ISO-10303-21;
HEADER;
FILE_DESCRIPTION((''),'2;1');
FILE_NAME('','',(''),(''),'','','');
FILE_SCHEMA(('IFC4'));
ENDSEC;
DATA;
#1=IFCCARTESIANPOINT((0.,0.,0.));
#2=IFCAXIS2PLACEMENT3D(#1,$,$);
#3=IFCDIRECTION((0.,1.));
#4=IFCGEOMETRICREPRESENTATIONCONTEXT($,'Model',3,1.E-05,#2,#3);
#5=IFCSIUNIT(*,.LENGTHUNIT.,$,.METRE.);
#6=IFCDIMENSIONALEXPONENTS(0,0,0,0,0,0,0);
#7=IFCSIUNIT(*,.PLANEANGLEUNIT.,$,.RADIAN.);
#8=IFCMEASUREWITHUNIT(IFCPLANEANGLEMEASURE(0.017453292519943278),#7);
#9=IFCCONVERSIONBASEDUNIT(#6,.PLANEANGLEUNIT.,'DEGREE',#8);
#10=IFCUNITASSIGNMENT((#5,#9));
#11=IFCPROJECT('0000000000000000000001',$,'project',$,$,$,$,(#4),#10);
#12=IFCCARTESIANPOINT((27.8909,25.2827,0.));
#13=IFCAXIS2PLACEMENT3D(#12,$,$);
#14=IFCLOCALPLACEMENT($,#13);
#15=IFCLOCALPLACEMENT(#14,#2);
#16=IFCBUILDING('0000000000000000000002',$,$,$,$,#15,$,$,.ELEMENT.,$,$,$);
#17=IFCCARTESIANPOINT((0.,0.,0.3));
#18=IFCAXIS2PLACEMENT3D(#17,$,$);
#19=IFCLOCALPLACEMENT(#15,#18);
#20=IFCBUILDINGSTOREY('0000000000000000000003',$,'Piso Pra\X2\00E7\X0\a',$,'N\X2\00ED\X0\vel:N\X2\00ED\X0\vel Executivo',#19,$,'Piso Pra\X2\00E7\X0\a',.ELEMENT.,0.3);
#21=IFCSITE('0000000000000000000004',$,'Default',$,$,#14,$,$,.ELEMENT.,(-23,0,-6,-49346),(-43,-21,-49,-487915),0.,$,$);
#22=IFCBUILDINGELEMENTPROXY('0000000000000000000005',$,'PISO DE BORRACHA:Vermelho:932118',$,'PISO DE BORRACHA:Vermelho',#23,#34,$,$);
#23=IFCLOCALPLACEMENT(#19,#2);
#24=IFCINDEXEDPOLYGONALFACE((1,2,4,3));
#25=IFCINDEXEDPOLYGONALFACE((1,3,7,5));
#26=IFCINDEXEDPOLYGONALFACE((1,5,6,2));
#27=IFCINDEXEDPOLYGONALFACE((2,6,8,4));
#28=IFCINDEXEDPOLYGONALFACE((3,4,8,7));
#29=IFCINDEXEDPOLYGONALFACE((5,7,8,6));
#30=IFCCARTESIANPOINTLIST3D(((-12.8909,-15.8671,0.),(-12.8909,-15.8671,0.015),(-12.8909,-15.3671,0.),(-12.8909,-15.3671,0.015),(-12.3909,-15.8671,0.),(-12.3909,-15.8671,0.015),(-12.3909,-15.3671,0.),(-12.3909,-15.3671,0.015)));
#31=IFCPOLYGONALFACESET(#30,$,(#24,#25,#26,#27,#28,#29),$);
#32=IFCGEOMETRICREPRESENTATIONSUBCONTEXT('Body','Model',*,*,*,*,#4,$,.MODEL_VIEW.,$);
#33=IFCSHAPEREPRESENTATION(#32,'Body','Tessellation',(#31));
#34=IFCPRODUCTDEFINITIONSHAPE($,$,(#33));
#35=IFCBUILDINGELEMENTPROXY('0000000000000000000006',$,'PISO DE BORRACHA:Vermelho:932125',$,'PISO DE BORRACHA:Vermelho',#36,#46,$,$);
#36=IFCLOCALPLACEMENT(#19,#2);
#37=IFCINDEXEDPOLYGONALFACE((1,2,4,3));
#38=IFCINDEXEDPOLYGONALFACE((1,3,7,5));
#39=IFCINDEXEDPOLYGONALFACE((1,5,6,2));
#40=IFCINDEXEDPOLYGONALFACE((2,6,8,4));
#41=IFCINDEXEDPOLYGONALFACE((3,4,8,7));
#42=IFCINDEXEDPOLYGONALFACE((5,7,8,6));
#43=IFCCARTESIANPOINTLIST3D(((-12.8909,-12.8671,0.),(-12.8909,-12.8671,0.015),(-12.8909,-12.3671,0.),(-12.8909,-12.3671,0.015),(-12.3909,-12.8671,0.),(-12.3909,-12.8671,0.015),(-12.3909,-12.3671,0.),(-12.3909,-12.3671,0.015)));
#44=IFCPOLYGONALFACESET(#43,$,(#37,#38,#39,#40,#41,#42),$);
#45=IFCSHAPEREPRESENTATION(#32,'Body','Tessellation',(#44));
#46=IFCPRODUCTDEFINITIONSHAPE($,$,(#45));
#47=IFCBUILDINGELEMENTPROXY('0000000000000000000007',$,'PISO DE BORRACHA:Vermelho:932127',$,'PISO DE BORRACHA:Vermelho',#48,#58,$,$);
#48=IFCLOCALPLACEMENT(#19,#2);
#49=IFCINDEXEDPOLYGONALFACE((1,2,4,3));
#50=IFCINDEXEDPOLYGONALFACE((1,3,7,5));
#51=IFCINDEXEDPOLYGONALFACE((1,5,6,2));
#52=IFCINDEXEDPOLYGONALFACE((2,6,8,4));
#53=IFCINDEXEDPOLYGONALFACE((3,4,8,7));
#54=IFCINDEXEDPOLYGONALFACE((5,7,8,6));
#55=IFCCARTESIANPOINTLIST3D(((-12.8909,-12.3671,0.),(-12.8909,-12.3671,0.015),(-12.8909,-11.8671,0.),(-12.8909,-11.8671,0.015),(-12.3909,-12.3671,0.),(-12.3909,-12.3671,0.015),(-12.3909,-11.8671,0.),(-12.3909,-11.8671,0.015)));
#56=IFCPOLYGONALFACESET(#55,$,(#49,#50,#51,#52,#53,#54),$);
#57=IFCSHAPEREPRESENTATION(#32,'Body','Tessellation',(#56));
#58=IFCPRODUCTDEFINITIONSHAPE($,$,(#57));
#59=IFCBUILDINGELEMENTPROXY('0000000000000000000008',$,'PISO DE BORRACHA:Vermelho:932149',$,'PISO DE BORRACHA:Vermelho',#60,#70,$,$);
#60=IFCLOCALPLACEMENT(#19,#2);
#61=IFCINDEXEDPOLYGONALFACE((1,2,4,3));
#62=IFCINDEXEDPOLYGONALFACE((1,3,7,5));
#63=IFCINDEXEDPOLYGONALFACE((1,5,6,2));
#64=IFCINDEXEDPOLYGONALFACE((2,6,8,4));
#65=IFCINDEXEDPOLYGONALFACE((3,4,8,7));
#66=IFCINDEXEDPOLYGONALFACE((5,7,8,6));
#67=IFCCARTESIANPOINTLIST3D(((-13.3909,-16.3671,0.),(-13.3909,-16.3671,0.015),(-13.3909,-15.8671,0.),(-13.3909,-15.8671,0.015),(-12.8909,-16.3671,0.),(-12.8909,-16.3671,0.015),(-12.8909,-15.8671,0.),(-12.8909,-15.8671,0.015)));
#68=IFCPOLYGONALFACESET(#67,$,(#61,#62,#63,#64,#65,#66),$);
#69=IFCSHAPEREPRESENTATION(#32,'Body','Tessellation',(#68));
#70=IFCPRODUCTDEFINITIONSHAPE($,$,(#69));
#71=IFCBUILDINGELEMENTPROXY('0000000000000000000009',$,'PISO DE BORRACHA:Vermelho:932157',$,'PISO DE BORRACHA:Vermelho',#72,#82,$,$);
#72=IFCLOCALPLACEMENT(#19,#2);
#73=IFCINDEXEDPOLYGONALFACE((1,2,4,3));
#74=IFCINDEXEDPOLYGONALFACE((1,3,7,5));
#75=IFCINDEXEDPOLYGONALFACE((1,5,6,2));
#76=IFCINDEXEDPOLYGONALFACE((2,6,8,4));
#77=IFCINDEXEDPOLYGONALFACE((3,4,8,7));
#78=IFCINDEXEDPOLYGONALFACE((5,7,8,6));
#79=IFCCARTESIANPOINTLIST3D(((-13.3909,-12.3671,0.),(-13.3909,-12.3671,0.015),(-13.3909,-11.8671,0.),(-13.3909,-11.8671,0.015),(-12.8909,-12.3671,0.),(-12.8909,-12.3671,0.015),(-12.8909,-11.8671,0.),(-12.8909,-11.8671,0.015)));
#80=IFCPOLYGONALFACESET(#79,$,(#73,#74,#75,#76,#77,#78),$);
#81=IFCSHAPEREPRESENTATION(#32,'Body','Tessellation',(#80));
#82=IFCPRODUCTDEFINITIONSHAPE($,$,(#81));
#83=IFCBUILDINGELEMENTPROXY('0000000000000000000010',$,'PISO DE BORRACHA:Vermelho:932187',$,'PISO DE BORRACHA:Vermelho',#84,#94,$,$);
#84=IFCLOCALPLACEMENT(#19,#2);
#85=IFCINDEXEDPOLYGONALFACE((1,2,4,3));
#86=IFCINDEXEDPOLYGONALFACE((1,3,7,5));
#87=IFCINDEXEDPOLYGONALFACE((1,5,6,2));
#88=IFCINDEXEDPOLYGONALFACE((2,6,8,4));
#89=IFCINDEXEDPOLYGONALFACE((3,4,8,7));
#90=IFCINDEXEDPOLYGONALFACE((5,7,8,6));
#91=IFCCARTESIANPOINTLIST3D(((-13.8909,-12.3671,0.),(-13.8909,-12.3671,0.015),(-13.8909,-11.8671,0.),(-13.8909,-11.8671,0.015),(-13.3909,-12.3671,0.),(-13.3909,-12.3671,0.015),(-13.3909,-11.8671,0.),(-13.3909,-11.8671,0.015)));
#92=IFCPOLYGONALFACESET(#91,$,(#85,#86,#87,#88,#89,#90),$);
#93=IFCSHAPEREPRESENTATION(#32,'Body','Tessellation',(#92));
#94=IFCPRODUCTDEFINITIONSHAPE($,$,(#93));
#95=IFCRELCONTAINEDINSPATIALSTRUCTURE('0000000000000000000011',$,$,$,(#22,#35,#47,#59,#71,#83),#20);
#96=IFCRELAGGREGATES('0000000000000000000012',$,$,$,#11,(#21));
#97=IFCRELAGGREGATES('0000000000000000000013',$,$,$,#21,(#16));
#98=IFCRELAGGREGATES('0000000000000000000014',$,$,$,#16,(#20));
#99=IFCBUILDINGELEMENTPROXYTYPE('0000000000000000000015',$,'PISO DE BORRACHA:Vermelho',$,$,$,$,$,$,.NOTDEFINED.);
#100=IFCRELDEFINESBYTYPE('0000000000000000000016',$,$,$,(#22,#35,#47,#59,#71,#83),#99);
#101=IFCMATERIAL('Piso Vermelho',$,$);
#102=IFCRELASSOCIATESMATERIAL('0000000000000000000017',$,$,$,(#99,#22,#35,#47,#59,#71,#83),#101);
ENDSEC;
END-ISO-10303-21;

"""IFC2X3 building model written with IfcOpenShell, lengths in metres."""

from ifc_helpers import new_model, entity, si_unit, converted_unit, direction, frame, origin, origin_2d_with_axis, place, context, subcontext, project, spatial, rectangle, extrude, source, transform, mapped, material, type_object, type_shapes, element, save


model = new_model("IFC2X3")

# Units and contexts
model_context = context("Model", 3, precision=1e-05, world=origin(), true_north=direction((0.0, 1.0)))
body_context = subcontext(model_context, "Body", "Model", "MODEL_VIEW")
ifc_project = project(units=[si_unit("LENGTHUNIT", "METRE"), converted_unit("PLANEANGLEUNIT", "DEGREE", entity("IfcPlaneAngleMeasure", 0.017453292519943278), si_unit("PLANEANGLEUNIT", "RADIAN"), dimensions=[0, 0, 0, 0, 0, 0, 0])], contexts=[model_context])

# Site, building, storey
site_placement = place(None, frame((27.8909, 25.2827, 0.0)))
site = spatial("IfcSite", under=ifc_project, at=site_placement, Name="Default", CompositionType="ELEMENT", RefLatitude=(-23, 0, -6, -49346), RefLongitude=(-43, -21, -49, -487915), RefElevation=0.0)
building_placement = place(site_placement, origin())
building = spatial("IfcBuilding", under=site, at=building_placement, CompositionType="ELEMENT")
storey_placement = place(building_placement, frame((0.0, 0.0, 0.3)))
storey = spatial("IfcBuildingStorey", under=building, at=storey_placement, Name="Piso Praça", ObjectType="Nível:Nível Executivo", LongName="Piso Praça", CompositionType="ELEMENT", Elevation=0.3)

# Building element proxies
ifc_material_1 = material(Name="Piso Vermelho")
building_element_proxy_type_1 = type_object("IfcBuildingElementProxyType", Name="PISO DE BORRACHA:Vermelho", PredefinedType="NOTDEFINED", material=ifc_material_1)
shared_shape_1 = source(origin(), body_context, "Body", "SweptSolid", [
    extrude(rectangle(XDim=0.5, YDim=0.5, at=origin_2d_with_axis()), frame((0.25, 0.25, 0.0), z_axis=(0.0, 0.0, 1.0), x_axis=(-1.0, 0.0, 0.0)), (0.0, 0.0, 1.0), 0.015),
])
type_shapes(building_element_proxy_type_1, [shared_shape_1])
for number, where, z_axis, x_axis, name in (
    (1, (-12.8909, -15.3671, 0.0), (0.0, 0.0, 1.0), (0.0, -1.0, 0.0), "PISO DE BORRACHA:Vermelho:932118"),
    (2, (-12.8909, -12.3671, 0.0), (0.0, 0.0, 1.0), (0.0, -1.0, 0.0), "PISO DE BORRACHA:Vermelho:932125"),
    (3, (-12.8909, -11.8671, 0.0), (0.0, 0.0, 1.0), (0.0, -1.0, 0.0), "PISO DE BORRACHA:Vermelho:932127"),
    (4, (-13.3909, -15.8671, 0.0), (0.0, 0.0, 1.0), (0.0, -1.0, 0.0), "PISO DE BORRACHA:Vermelho:932149"),
    (5, (-13.3909, -11.8671, 0.0), (0.0, 0.0, 1.0), (0.0, -1.0, 0.0), "PISO DE BORRACHA:Vermelho:932157"),
    (6, (-13.8909, -11.8671, 0.0), (0.0, 0.0, 1.0), (0.0, -1.0, 0.0), "PISO DE BORRACHA:Vermelho:932187"),
):
    element("IfcBuildingElementProxy", number, at=place(storey_placement, frame(where, z_axis=z_axis, x_axis=x_axis)), inside=storey, type_object=building_element_proxy_type_1, material=ifc_material_1, Name=name, ObjectType="PISO DE BORRACHA:Vermelho", context=body_context, shape_type="MappedRepresentation", body=[
        mapped(shared_shape_1, transform((0.0, 0.0, 0.0), scale=1.0)),
    ])

save(model, "model.ifc")
